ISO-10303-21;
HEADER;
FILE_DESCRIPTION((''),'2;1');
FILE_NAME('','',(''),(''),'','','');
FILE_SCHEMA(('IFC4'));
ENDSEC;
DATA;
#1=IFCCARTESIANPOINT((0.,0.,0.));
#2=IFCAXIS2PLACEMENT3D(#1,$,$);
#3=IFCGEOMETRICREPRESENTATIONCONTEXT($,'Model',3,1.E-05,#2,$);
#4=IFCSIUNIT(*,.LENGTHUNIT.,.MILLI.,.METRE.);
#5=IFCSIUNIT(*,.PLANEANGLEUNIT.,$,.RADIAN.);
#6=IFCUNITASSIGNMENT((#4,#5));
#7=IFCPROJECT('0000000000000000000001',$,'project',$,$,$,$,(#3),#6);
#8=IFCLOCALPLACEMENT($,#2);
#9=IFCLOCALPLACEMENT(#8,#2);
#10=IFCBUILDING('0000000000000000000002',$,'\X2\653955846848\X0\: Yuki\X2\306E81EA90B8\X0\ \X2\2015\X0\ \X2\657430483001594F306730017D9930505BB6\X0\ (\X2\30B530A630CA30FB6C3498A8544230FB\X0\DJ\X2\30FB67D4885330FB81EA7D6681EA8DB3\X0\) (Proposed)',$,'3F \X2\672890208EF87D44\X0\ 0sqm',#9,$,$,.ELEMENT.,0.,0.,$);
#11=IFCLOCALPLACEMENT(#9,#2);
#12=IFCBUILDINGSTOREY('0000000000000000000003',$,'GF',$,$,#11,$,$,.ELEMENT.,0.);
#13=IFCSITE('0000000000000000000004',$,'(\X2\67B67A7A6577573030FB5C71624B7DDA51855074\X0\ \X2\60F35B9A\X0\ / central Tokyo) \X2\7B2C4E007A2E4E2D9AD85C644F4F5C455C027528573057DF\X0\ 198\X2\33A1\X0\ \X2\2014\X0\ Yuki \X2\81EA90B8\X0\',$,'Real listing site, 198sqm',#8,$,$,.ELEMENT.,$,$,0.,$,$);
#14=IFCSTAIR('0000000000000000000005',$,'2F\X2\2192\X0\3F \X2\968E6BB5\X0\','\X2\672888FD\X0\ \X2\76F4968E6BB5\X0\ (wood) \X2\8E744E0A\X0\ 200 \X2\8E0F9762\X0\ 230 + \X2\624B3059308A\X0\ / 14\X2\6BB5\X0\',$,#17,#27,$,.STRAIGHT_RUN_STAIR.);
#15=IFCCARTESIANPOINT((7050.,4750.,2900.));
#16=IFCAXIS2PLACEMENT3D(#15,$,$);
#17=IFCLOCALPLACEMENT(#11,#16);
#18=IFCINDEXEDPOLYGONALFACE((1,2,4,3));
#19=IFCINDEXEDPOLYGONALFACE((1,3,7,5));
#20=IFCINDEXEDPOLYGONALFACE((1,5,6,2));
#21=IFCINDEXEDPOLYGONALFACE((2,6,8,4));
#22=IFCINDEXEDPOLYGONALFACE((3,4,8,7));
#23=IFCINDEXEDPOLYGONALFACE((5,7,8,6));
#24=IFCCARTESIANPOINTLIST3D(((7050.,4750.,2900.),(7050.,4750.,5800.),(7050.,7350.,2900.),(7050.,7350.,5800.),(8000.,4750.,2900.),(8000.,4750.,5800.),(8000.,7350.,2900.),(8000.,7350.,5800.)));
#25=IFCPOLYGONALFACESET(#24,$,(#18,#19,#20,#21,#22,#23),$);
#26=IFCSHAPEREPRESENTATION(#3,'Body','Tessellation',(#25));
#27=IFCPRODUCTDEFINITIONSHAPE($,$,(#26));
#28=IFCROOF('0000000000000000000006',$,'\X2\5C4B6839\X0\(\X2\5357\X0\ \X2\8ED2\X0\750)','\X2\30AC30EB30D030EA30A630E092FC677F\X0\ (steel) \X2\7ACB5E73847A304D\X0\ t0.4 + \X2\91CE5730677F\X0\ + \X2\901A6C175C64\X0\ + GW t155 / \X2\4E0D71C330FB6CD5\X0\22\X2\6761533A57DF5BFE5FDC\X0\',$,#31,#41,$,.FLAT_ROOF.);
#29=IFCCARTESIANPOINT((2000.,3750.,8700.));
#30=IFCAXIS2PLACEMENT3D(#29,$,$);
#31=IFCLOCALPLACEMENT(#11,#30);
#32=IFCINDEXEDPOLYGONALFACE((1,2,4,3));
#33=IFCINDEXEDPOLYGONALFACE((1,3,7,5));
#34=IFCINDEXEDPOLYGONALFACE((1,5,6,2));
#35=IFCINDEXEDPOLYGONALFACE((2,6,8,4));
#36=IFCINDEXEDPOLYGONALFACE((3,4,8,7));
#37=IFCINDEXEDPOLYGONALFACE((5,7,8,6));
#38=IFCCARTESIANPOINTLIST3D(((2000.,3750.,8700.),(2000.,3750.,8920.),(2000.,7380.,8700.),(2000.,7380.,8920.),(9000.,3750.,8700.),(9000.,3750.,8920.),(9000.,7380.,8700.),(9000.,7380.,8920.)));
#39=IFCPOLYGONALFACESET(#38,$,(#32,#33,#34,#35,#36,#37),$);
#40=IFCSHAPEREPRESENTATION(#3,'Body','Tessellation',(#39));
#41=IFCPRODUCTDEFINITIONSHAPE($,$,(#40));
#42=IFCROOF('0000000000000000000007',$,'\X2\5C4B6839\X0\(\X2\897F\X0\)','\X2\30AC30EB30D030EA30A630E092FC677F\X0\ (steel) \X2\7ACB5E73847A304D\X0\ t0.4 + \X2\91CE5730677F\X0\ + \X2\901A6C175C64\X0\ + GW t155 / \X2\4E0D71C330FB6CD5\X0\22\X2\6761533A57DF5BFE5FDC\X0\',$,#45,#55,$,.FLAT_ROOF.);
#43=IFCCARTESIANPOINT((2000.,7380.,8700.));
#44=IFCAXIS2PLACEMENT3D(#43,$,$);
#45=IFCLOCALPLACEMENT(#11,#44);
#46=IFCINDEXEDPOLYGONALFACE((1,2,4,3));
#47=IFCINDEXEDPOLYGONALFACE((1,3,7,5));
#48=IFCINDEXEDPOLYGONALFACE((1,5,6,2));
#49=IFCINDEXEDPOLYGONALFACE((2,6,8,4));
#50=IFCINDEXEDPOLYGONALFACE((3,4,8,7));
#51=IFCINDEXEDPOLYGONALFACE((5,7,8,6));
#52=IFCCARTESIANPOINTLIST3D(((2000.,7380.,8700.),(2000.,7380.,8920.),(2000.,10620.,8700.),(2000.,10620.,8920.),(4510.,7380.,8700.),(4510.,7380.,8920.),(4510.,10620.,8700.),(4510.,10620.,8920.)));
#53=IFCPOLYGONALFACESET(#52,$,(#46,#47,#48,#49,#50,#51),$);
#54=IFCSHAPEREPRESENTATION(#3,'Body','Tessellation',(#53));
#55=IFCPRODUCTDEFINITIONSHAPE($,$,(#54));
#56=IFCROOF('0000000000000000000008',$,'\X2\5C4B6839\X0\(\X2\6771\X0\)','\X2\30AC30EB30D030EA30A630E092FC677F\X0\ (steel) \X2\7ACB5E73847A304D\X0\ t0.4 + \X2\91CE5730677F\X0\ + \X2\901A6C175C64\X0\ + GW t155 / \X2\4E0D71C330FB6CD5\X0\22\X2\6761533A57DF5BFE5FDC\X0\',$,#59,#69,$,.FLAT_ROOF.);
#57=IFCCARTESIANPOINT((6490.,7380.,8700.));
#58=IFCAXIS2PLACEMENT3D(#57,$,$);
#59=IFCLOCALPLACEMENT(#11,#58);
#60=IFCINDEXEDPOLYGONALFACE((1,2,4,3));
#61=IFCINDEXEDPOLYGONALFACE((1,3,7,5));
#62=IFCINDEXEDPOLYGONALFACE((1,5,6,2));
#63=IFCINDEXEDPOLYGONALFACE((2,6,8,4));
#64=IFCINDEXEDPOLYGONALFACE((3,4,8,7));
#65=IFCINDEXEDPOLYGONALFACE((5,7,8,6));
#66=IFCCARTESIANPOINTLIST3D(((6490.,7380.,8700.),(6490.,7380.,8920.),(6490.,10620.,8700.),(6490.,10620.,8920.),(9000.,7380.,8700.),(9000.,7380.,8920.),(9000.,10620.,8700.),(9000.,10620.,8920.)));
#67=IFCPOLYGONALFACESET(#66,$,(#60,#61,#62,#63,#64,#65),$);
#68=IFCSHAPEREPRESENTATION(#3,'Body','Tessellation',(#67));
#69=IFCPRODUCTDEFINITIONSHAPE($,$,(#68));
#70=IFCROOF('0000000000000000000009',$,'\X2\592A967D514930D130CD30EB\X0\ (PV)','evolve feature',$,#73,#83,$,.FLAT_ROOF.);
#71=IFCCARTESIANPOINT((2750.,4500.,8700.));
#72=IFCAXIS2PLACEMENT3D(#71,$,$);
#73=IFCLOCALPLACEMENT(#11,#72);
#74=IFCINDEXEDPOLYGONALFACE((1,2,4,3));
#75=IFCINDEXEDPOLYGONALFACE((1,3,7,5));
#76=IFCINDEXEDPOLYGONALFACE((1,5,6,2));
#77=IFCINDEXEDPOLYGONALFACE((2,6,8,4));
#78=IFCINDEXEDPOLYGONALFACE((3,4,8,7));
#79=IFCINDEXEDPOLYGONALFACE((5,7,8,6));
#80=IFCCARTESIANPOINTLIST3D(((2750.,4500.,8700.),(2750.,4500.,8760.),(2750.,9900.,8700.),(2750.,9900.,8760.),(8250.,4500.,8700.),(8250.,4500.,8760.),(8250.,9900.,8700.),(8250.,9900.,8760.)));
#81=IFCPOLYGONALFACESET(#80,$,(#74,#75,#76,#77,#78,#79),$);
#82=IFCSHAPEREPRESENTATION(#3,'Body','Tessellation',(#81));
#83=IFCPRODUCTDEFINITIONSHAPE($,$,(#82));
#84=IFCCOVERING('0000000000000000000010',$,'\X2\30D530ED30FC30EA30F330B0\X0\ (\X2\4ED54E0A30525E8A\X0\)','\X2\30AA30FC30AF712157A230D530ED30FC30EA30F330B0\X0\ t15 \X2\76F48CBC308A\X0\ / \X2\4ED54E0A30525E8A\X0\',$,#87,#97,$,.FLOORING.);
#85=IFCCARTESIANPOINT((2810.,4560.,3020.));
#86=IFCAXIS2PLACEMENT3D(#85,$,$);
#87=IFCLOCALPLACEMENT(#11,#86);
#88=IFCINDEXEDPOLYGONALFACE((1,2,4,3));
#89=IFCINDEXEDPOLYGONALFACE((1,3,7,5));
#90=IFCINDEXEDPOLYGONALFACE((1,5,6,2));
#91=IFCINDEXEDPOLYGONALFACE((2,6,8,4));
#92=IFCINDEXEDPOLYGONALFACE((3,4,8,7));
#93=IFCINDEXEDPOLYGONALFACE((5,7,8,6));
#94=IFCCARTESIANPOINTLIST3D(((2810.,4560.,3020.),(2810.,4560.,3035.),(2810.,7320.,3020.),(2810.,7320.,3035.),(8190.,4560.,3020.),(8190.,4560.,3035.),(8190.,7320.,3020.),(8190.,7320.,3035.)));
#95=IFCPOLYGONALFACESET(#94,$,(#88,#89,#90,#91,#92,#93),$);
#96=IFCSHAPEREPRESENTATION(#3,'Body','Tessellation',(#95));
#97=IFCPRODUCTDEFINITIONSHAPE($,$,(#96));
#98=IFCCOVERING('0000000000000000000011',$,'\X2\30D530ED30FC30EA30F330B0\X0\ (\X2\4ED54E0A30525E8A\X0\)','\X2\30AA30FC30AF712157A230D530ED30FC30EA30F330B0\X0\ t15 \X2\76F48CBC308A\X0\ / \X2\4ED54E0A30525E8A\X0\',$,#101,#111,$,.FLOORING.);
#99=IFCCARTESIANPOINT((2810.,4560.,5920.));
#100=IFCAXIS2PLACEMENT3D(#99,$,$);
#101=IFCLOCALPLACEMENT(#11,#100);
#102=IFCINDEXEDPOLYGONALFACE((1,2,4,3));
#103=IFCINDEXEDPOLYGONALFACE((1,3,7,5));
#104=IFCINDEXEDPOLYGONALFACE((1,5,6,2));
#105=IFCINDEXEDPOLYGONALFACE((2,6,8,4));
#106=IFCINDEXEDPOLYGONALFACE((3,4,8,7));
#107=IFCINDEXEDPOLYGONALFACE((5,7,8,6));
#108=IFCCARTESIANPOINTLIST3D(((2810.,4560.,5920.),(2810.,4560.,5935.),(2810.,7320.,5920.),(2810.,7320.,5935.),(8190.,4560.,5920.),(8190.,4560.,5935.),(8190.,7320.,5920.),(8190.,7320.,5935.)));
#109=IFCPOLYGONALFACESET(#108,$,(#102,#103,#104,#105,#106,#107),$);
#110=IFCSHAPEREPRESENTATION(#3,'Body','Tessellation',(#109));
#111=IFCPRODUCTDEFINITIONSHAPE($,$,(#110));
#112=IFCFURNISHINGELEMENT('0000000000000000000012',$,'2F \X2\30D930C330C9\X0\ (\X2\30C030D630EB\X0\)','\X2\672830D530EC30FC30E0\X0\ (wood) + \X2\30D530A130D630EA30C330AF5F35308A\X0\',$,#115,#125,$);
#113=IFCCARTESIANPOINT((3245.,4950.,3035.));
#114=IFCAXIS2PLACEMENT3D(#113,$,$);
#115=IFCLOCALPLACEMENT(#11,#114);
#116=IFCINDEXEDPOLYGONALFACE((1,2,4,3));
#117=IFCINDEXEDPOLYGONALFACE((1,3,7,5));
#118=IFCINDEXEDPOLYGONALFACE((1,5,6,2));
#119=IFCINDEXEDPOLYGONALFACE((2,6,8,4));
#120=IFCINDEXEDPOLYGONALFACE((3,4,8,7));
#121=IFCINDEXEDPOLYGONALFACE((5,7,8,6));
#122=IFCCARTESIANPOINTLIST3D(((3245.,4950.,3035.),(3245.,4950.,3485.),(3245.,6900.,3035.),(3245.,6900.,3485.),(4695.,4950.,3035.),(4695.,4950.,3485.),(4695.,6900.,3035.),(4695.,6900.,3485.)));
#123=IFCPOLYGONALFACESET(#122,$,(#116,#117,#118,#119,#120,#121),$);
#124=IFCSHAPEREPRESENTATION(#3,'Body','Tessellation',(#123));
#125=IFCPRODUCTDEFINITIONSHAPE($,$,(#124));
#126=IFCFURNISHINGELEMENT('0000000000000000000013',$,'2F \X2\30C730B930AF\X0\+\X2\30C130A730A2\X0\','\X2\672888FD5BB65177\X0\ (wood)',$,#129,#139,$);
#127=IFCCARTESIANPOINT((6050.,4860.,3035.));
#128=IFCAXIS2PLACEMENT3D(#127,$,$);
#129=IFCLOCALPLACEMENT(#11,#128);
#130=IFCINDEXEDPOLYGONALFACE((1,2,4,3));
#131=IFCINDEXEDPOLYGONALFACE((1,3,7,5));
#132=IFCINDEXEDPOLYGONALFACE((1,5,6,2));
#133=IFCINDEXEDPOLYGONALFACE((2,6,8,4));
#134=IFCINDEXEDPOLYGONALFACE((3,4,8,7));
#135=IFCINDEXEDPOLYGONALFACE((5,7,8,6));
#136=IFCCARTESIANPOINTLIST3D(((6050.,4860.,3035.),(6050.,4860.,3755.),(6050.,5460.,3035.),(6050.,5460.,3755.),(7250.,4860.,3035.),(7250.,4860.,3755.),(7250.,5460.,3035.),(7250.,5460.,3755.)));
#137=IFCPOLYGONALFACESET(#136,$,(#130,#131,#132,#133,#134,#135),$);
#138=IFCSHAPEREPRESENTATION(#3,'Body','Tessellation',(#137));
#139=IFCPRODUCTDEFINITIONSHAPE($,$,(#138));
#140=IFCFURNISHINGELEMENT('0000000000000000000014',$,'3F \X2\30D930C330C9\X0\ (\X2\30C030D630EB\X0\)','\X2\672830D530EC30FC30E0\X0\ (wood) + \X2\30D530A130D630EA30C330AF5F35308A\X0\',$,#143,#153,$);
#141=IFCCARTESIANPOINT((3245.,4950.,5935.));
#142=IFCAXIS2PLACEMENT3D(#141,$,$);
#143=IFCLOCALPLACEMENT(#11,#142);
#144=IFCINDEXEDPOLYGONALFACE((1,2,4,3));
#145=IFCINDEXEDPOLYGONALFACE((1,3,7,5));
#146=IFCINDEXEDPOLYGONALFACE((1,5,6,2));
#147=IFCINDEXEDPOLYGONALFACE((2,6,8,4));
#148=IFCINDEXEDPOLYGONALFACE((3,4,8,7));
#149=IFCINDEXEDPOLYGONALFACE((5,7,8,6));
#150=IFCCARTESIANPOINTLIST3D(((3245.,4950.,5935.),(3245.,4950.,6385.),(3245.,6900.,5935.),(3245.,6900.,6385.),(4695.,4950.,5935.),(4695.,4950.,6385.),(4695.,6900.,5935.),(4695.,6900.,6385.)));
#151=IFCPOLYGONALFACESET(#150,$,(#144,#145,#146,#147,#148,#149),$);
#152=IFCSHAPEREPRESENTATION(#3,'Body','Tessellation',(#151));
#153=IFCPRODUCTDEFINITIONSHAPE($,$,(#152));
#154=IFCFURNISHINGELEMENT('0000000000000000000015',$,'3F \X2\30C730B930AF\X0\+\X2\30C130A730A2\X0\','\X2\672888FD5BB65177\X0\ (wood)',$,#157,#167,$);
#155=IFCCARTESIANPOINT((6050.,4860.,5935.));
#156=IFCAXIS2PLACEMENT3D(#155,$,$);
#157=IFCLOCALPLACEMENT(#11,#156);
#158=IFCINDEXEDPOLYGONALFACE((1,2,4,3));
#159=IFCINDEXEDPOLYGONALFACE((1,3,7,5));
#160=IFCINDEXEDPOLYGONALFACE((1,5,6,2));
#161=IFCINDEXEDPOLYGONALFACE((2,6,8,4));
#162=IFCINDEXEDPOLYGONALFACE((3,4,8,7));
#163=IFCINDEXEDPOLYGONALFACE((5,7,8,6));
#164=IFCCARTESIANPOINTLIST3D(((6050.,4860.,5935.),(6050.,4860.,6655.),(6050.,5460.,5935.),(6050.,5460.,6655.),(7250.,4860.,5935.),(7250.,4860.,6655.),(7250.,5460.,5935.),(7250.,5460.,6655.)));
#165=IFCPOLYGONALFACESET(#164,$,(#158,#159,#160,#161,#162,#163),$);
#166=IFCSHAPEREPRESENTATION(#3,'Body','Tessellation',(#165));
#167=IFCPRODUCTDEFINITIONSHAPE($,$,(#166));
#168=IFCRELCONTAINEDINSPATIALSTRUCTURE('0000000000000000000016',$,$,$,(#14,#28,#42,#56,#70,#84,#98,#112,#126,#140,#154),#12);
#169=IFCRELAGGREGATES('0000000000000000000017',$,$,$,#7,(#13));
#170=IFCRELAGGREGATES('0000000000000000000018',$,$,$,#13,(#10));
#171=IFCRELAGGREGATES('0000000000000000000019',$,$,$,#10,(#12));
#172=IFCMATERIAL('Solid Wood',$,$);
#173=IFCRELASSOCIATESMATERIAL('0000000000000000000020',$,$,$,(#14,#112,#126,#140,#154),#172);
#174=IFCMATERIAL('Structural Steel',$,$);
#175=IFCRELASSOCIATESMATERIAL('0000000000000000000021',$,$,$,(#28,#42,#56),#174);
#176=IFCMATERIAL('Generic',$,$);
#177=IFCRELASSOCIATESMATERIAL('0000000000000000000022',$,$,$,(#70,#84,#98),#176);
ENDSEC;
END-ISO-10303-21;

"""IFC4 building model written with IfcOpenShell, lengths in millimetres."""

from ifc_helpers import new_model, si_unit, frame, frame_2d, origin, place, context, project, spatial, rectangle, extrude, material, element, save


model = new_model("IFC4")

# Units and contexts
model_context = context("Model", 3, precision=1e-05, world=origin())
ifc_project = project(units=[si_unit("LENGTHUNIT", "METRE", prefix="MILLI"), si_unit("PLANEANGLEUNIT", "RADIAN")], contexts=[model_context])

# Site, building, storey
site_placement = place(None, origin())
site = spatial("IfcSite", under=ifc_project, at=site_placement, Name="(架空敷地・山手線内側 想定 / central Tokyo) 第一種中高層住居専用地域 198㎡ — Yuki 自邸", ObjectType="Real listing site, 198sqm", CompositionType="ELEMENT", RefElevation=0.0)
building_placement = place(site_placement, origin())
building = spatial("IfcBuilding", under=site, at=building_placement, Name="改善案: Yukiの自邸 ― 整え、奏で、継ぐ家 (サウナ・水風呂・DJ・柔術・自給自足) (Proposed)", ObjectType="3F 木造軸組 0sqm", CompositionType="ELEMENT", ElevationOfRefHeight=0.0, ElevationOfTerrain=0.0)
storey_placement = place(building_placement, origin())
storey = spatial("IfcBuildingStorey", under=building, at=storey_placement, Name="GF", CompositionType="ELEMENT", Elevation=0.0)

# Shared definitions
ifc_material_1 = material(Name="Solid Wood")

# Stair
stair_placement = place(storey_placement, frame((7050.0, 4750.0, 2900.0)))
element("IfcStair", 1, at=stair_placement, inside=storey, material=ifc_material_1, Name="2F→3F 階段", Description="木製 直階段 (wood) 蹴上 200 踏面 230 + 手すり / 14段", PredefinedType="STRAIGHT_RUN_STAIR", context=model_context, shape_type="SweptSolid", body=[
    extrude(rectangle(XDim=950.0, YDim=2600.0, at=frame_2d((475.0, 1300.0))), frame((7050.0, 4750.0, 2900.0)), (0.0, 0.0, 1.0), 2900.0),
])

# Roofs
ifc_material_2 = material(Name="Structural Steel")
roof_1_placement = place(storey_placement, frame((2000.0, 3750.0, 8700.0)))
element("IfcRoof", 2, at=roof_1_placement, inside=storey, material=ifc_material_2, Name="屋根(南 軒750)", Description="ガルバリウム鋼板 (steel) 立平葺き t0.4 + 野地板 + 通気層 + GW t155 / 不燃・法22条区域対応", PredefinedType="FLAT_ROOF", context=model_context, shape_type="SweptSolid", body=[
    extrude(rectangle(XDim=7000.0, YDim=3630.0, at=frame_2d((3500.0, 1815.0))), frame((2000.0, 3750.0, 8700.0)), (0.0, 0.0, 1.0), 220.0),
])
roof_2_placement = place(storey_placement, frame((2000.0, 7380.0, 8700.0)))
element("IfcRoof", 3, at=roof_2_placement, inside=storey, material=ifc_material_2, Name="屋根(西)", Description="ガルバリウム鋼板 (steel) 立平葺き t0.4 + 野地板 + 通気層 + GW t155 / 不燃・法22条区域対応", PredefinedType="FLAT_ROOF", context=model_context, shape_type="SweptSolid", body=[
    extrude(rectangle(XDim=2510.0, YDim=3240.0, at=frame_2d((1255.0, 1620.0))), frame((2000.0, 7380.0, 8700.0)), (0.0, 0.0, 1.0), 220.0),
])
roof_3_placement = place(storey_placement, frame((6490.0, 7380.0, 8700.0)))
element("IfcRoof", 4, at=roof_3_placement, inside=storey, material=ifc_material_2, Name="屋根(東)", Description="ガルバリウム鋼板 (steel) 立平葺き t0.4 + 野地板 + 通気層 + GW t155 / 不燃・法22条区域対応", PredefinedType="FLAT_ROOF", context=model_context, shape_type="SweptSolid", body=[
    extrude(rectangle(XDim=2510.0, YDim=3240.0, at=frame_2d((1255.0, 1620.0))), frame((6490.0, 7380.0, 8700.0)), (0.0, 0.0, 1.0), 220.0),
])
ifc_material_3 = material(Name="Generic")
roof_4_placement = place(storey_placement, frame((2750.0, 4500.0, 8700.0)))
element("IfcRoof", 5, at=roof_4_placement, inside=storey, material=ifc_material_3, Name="太陽光パネル (PV)", Description="evolve feature", PredefinedType="FLAT_ROOF", context=model_context, shape_type="SweptSolid", body=[
    extrude(rectangle(XDim=5500.0, YDim=5400.0, at=frame_2d((2750.0, 2700.0))), frame((2750.0, 4500.0, 8700.0)), (0.0, 0.0, 1.0), 60.0),
])

# Coverings
covering_1_placement = place(storey_placement, frame((2810.0, 4560.0, 3020.0)))
element("IfcCovering", 6, at=covering_1_placement, inside=storey, material=ifc_material_3, Name="フローリング (仕上げ床)", Description="オーク無垢フローリング t15 直貼り / 仕上げ床", PredefinedType="FLOORING", context=model_context, shape_type="SweptSolid", body=[
    extrude(rectangle(XDim=5380.0, YDim=2760.0, at=frame_2d((2690.0, 1380.0))), frame((2810.0, 4560.0, 3020.0)), (0.0, 0.0, 1.0), 15.0),
])
covering_2_placement = place(storey_placement, frame((2810.0, 4560.0, 5920.0)))
element("IfcCovering", 7, at=covering_2_placement, inside=storey, material=ifc_material_3, Name="フローリング (仕上げ床)", Description="オーク無垢フローリング t15 直貼り / 仕上げ床", PredefinedType="FLOORING", context=model_context, shape_type="SweptSolid", body=[
    extrude(rectangle(XDim=5380.0, YDim=2760.0, at=frame_2d((2690.0, 1380.0))), frame((2810.0, 4560.0, 5920.0)), (0.0, 0.0, 1.0), 15.0),
])

# Furnishing elements
furnishing_1_placement = place(storey_placement, frame((3245.0, 4950.0, 3035.0)))
element("IfcFurnishingElement", 8, at=furnishing_1_placement, inside=storey, material=ifc_material_1, Name="2F ベッド (ダブル)", Description="木フレーム (wood) + ファブリック張り", context=model_context, shape_type="SweptSolid", body=[
    extrude(rectangle(XDim=1450.0, YDim=1950.0, at=frame_2d((725.0, 975.0))), frame((3245.0, 4950.0, 3035.0)), (0.0, 0.0, 1.0), 450.0),
])
furnishing_2_placement = place(storey_placement, frame((6050.0, 4860.0, 3035.0)))
element("IfcFurnishingElement", 9, at=furnishing_2_placement, inside=storey, material=ifc_material_1, Name="2F デスク+チェア", Description="木製家具 (wood)", context=model_context, shape_type="SweptSolid", body=[
    extrude(rectangle(XDim=1200.0, YDim=600.0, at=frame_2d((600.0, 300.0))), frame((6050.0, 4860.0, 3035.0)), (0.0, 0.0, 1.0), 720.0),
])
furnishing_3_placement = place(storey_placement, frame((3245.0, 4950.0, 5935.0)))
element("IfcFurnishingElement", 10, at=furnishing_3_placement, inside=storey, material=ifc_material_1, Name="3F ベッド (ダブル)", Description="木フレーム (wood) + ファブリック張り", context=model_context, shape_type="SweptSolid", body=[
    extrude(rectangle(XDim=1450.0, YDim=1950.0, at=frame_2d((725.0, 975.0))), frame((3245.0, 4950.0, 5935.0)), (0.0, 0.0, 1.0), 450.0),
])
furnishing_4_placement = place(storey_placement, frame((6050.0, 4860.0, 5935.0)))
element("IfcFurnishingElement", 11, at=furnishing_4_placement, inside=storey, material=ifc_material_1, Name="3F デスク+チェア", Description="木製家具 (wood)", context=model_context, shape_type="SweptSolid", body=[
    extrude(rectangle(XDim=1200.0, YDim=600.0, at=frame_2d((600.0, 300.0))), frame((6050.0, 4860.0, 5935.0)), (0.0, 0.0, 1.0), 720.0),
])

save(model, "model.ifc")
